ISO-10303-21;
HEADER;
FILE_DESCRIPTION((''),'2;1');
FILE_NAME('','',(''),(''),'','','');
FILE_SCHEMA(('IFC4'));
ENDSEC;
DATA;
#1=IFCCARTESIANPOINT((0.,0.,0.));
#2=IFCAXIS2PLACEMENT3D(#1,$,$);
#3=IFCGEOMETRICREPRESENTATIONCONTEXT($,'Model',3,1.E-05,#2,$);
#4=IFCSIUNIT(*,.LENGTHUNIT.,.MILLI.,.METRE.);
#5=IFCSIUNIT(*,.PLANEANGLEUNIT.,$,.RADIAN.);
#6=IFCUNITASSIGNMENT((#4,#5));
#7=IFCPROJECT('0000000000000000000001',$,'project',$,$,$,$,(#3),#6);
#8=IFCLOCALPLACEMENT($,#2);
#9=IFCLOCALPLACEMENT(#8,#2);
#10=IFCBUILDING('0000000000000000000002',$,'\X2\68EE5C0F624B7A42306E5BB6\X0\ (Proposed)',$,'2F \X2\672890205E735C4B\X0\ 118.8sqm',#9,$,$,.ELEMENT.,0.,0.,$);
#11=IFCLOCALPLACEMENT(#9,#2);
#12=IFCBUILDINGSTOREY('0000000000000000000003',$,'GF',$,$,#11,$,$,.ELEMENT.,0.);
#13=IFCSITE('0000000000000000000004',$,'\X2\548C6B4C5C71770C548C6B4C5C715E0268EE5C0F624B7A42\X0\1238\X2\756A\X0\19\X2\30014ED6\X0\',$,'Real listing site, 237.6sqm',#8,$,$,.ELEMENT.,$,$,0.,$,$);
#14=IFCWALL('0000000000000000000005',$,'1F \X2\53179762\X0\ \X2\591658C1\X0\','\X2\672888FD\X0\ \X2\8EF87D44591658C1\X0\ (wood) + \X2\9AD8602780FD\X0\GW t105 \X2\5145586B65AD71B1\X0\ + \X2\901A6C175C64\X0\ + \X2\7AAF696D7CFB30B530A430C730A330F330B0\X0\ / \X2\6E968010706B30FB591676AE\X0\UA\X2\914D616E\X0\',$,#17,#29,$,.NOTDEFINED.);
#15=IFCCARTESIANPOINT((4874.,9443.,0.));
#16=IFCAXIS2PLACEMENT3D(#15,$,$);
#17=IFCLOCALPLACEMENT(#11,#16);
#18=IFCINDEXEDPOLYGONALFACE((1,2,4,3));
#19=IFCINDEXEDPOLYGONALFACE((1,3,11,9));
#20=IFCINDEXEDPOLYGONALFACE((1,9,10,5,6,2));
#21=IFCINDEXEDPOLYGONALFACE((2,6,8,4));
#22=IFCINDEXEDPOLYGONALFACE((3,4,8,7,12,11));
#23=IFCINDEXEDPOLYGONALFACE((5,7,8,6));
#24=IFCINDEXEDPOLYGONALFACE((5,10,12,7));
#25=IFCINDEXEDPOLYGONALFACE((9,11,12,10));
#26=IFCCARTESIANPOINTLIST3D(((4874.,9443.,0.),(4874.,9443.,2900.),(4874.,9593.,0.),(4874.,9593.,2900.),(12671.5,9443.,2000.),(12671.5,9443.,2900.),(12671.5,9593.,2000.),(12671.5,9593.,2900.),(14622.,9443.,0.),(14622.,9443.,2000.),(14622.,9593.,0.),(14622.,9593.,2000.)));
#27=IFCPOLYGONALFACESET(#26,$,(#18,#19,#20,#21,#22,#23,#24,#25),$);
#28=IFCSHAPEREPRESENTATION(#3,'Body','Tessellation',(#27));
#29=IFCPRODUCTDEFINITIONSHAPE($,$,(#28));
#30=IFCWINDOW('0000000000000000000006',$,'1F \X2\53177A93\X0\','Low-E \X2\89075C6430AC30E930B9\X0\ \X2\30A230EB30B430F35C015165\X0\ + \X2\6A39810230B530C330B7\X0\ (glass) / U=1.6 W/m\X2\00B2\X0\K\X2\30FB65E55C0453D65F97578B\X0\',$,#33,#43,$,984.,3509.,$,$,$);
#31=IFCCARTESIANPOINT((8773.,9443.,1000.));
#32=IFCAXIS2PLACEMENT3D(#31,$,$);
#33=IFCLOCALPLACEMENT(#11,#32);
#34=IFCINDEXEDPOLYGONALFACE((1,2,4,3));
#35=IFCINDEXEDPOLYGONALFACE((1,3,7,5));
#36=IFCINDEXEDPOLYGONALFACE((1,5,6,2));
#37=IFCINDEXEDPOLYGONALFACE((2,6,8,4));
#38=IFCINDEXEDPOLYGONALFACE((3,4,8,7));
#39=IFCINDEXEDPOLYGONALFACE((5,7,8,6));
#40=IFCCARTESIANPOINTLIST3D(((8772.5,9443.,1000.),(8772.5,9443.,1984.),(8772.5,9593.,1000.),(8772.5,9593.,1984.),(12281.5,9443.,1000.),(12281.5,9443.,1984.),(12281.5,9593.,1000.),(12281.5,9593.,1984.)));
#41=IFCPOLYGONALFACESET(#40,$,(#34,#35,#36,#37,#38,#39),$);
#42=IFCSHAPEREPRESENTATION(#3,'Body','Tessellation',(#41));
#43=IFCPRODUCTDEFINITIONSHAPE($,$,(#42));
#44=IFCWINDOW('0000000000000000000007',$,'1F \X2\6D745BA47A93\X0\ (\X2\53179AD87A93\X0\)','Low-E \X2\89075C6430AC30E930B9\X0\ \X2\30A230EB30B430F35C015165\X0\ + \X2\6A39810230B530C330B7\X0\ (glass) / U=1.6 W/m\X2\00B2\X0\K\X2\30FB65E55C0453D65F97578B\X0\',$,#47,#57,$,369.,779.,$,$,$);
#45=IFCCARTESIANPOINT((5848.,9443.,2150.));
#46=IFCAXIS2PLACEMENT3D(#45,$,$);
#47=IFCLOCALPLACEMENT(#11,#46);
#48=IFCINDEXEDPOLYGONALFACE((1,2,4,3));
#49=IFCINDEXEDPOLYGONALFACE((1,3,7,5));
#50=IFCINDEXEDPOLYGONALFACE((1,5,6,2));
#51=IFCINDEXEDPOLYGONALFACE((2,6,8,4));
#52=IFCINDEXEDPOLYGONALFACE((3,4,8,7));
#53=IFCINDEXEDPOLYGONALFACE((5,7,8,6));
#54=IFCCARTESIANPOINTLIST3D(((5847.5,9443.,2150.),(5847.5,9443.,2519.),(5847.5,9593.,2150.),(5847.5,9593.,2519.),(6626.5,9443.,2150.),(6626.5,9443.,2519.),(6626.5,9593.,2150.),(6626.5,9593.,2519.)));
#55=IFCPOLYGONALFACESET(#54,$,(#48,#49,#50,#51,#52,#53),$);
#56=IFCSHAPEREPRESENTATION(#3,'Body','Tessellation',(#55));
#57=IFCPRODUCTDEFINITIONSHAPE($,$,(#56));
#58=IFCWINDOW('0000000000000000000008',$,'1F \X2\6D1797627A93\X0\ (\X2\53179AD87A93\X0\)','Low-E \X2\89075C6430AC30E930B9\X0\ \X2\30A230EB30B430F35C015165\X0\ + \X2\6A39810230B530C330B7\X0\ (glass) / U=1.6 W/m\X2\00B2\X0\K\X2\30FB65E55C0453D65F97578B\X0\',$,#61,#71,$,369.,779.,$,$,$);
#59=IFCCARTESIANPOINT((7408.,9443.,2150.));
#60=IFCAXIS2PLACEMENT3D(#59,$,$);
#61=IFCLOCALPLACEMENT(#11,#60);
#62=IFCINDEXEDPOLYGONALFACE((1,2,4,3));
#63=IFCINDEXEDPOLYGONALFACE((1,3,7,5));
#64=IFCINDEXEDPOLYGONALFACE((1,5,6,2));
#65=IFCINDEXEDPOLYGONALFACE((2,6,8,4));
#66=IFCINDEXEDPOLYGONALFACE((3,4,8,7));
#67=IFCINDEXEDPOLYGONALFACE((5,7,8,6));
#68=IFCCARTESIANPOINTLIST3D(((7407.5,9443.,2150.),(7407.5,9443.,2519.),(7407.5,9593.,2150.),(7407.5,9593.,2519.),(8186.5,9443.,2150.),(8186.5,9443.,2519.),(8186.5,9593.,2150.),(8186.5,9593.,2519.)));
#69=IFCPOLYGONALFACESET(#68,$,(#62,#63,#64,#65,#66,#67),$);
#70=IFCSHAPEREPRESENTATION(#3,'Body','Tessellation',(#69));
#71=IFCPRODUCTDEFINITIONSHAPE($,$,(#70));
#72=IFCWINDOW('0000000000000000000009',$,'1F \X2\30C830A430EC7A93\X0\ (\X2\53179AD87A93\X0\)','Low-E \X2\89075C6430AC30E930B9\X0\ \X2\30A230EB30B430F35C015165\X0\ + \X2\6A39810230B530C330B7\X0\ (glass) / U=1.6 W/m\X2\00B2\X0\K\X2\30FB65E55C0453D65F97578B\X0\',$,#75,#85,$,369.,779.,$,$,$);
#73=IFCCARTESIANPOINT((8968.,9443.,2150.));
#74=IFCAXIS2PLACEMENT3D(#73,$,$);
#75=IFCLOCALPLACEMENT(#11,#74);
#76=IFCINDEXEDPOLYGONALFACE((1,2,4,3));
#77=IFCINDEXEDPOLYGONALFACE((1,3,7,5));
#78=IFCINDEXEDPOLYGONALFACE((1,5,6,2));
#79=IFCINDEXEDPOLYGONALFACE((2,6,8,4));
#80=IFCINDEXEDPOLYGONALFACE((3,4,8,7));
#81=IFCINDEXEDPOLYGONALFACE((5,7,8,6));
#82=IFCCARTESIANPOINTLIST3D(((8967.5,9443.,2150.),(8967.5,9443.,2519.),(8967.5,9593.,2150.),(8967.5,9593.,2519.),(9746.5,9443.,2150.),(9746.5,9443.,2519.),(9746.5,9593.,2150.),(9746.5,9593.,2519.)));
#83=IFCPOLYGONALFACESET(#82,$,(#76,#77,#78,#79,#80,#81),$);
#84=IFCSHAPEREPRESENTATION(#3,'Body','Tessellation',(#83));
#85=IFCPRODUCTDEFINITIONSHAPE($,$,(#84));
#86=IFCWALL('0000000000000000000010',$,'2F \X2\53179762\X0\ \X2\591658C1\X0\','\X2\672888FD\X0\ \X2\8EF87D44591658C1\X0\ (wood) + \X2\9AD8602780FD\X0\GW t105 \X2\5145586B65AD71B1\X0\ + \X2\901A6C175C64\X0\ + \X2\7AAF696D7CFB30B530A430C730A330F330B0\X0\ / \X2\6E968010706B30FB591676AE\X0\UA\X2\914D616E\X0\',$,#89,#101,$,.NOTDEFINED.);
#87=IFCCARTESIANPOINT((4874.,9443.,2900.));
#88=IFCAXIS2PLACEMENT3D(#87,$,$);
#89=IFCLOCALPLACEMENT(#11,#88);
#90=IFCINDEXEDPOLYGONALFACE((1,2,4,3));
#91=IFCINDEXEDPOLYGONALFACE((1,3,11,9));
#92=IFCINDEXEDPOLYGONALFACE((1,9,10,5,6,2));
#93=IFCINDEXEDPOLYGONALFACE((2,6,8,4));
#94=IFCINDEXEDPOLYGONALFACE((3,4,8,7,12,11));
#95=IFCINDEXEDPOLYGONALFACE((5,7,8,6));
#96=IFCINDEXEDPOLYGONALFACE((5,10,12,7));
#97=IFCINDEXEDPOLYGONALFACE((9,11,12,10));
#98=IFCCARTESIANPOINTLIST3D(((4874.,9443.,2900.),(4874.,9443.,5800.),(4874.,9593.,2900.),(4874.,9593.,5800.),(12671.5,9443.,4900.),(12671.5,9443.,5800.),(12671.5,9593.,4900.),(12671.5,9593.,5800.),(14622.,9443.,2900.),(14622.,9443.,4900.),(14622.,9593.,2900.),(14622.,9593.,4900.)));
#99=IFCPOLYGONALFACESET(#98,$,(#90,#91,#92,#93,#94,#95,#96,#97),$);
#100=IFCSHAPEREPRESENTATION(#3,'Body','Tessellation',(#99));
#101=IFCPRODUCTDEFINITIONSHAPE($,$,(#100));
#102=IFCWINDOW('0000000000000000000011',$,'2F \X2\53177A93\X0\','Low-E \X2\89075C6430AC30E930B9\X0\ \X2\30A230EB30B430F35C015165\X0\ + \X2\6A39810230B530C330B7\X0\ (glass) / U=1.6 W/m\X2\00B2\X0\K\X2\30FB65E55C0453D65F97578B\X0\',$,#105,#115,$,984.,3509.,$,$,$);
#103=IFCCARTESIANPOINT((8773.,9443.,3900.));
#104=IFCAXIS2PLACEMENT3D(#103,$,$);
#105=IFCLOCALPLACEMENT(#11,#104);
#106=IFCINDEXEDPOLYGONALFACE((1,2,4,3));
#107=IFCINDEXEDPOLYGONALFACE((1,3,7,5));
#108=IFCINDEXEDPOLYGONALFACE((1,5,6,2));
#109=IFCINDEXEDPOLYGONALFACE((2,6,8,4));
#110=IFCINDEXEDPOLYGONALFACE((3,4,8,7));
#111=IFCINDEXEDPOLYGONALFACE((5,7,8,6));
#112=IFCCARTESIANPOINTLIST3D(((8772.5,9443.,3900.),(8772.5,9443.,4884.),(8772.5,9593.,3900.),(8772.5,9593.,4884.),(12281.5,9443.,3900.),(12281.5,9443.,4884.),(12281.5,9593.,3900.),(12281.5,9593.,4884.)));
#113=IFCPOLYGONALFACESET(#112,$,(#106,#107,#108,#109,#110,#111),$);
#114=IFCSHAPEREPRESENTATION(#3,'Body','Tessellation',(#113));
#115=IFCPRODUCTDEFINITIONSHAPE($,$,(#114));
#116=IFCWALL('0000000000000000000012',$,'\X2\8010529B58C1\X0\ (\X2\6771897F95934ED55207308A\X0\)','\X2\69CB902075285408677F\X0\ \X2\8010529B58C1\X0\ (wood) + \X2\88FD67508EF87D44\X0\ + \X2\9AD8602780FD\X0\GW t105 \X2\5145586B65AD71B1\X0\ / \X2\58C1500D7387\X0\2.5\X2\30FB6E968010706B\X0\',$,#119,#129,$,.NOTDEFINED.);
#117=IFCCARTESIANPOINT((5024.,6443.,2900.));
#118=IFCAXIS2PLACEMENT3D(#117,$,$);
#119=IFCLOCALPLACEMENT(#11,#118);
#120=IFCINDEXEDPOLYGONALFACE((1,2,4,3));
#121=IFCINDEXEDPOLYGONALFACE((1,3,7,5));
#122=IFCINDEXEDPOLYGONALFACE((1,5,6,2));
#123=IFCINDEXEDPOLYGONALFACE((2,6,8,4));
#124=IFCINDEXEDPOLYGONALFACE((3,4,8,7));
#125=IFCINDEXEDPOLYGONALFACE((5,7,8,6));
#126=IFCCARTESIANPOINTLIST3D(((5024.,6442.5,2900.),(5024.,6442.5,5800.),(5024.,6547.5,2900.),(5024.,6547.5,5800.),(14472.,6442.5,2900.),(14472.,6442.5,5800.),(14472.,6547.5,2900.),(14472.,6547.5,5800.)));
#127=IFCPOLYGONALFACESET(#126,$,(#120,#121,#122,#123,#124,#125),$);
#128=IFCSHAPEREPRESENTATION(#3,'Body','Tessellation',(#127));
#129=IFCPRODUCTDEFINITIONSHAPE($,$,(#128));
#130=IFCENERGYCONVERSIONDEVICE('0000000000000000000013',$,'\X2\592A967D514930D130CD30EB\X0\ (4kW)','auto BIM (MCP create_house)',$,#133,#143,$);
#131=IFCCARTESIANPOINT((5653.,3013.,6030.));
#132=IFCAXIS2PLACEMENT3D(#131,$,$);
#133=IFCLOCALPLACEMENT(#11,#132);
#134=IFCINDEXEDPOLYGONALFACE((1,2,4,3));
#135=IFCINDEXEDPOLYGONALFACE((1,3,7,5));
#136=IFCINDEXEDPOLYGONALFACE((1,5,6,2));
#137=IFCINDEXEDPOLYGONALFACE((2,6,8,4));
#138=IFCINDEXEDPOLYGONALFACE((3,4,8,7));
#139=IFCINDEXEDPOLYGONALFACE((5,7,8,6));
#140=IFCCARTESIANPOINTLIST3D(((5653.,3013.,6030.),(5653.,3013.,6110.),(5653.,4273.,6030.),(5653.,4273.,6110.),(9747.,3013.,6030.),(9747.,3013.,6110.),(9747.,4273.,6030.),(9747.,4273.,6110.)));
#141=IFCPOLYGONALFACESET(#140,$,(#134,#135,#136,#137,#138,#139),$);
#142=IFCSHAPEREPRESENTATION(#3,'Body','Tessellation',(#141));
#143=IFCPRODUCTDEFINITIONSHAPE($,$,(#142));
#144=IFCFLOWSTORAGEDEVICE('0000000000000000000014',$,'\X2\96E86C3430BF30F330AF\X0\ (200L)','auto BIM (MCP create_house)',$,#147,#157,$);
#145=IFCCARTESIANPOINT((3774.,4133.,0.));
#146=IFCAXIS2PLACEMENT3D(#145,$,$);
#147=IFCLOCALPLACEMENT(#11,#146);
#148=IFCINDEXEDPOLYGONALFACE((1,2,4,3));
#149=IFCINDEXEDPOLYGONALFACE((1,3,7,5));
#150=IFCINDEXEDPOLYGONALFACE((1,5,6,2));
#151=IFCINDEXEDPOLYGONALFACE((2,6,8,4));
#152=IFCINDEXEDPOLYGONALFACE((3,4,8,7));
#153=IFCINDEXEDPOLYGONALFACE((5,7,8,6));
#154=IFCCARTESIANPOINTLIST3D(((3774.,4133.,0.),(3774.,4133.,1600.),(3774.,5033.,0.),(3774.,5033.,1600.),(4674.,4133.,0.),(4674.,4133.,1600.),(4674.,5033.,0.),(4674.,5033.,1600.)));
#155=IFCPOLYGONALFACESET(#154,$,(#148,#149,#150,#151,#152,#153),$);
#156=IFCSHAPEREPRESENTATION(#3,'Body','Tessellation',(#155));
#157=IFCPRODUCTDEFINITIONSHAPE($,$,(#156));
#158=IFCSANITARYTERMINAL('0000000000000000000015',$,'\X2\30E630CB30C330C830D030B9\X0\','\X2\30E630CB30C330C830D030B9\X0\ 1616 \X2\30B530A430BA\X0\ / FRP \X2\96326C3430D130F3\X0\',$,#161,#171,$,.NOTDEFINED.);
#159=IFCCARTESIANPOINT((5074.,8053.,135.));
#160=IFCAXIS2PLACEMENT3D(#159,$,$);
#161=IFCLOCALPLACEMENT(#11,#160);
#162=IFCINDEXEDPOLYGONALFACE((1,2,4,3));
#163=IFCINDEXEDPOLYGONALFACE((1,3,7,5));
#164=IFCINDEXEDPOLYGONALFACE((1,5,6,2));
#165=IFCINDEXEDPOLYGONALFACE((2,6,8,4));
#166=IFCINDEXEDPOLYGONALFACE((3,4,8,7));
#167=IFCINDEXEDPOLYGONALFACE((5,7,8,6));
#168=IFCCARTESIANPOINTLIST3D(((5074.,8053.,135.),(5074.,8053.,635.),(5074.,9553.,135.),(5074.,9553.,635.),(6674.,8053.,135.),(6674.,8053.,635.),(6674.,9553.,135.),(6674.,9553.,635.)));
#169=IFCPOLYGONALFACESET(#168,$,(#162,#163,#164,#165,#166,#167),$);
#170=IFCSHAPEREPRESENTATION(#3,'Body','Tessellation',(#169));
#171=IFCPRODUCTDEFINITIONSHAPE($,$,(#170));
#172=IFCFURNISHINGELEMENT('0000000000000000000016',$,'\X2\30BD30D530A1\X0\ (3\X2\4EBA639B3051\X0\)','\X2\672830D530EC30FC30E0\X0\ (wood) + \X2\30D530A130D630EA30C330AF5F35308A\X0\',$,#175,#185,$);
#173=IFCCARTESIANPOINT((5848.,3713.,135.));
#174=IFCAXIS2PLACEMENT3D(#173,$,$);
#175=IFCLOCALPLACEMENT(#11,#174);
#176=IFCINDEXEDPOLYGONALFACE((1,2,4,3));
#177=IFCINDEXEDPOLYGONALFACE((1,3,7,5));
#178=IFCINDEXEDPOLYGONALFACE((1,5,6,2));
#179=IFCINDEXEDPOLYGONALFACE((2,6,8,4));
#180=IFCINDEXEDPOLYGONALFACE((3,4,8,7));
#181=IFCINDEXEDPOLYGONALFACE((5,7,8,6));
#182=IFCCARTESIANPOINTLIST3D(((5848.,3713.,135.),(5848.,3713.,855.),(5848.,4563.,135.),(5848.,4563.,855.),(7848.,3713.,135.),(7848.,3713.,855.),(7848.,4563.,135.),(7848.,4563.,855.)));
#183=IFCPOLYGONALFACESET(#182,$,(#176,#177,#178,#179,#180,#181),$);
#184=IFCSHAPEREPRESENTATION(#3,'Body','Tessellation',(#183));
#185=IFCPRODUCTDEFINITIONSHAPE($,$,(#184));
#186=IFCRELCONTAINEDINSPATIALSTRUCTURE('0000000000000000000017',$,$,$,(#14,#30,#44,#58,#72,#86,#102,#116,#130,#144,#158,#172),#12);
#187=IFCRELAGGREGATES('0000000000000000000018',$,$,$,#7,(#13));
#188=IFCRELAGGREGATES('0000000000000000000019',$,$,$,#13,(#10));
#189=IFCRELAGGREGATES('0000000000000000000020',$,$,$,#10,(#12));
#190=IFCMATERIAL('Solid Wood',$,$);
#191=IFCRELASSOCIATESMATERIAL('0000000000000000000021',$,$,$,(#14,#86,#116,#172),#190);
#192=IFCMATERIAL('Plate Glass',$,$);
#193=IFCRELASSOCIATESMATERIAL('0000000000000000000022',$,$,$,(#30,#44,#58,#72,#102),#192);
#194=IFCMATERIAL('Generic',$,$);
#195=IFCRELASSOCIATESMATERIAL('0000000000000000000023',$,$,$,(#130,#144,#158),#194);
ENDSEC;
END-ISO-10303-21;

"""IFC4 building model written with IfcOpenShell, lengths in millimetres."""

from ifc_helpers import new_model, si_unit, frame, frame_2d, origin, place, context, project, spatial, rectangle, extrude, material, element, fill, save


model = new_model("IFC4")

# Units and contexts
model_context = context("Model", 3, precision=1e-05, world=origin())
ifc_project = project(units=[si_unit("LENGTHUNIT", "METRE", prefix="MILLI"), si_unit("PLANEANGLEUNIT", "RADIAN")], contexts=[model_context])

# Site, building, storey
site_placement = place(None, origin())
site = spatial("IfcSite", under=ifc_project, at=site_placement, Name="和歌山県和歌山市森小手穂1238番19、他", ObjectType="Real listing site, 237.6sqm", CompositionType="ELEMENT", RefElevation=0.0)
building_placement = place(site_placement, origin())
building = spatial("IfcBuilding", under=site, at=building_placement, Name="森小手穂の家 (Proposed)", ObjectType="2F 木造平屋 118.8sqm", CompositionType="ELEMENT", ElevationOfRefHeight=0.0, ElevationOfTerrain=0.0)
storey_placement = place(building_placement, origin())
storey = spatial("IfcBuildingStorey", under=building, at=storey_placement, Name="GF", CompositionType="ELEMENT", Elevation=0.0)

# Wall, openings, windows
ifc_material_1 = material(Name="Solid Wood")
wall_1_placement = place(storey_placement, frame((4874.0, 9443.0, 0.0)))
wall_1 = element("IfcWall", 1, at=wall_1_placement, inside=storey, material=ifc_material_1, Name="1F 北面 外壁", Description="木製 軸組外壁 (wood) + 高性能GW t105 充填断熱 + 通気層 + 窯業系サイディング / 準耐火・外皮UA配慮", PredefinedType="NOTDEFINED", context=model_context, shape_type="SweptSolid", body=[
    extrude(rectangle(XDim=9748.0, YDim=150.0, at=frame_2d((4874.0, 75.0))), frame((4874.0, 9443.0, 0.0)), (0.0, 0.0, 1.0), 2900.0),
])
opening_1_placement = place(storey_placement, frame((8773.0, 9443.0, 1000.0)))
opening_1 = element("IfcOpeningElement", 2, at=opening_1_placement, cuts=wall_1, PredefinedType="NOTDEFINED", context=model_context, shape_type="SweptSolid", body=[
    extrude(rectangle(XDim=3509.0, YDim=150.0, at=frame_2d((1754.0, 75.0))), frame((8773.0, 9443.0, 1000.0)), (0.0, 0.0, 1.0), 984.0),
])
opening_2_placement = place(storey_placement, frame((5848.0, 9443.0, 2150.0)))
opening_2 = element("IfcOpeningElement", 3, at=opening_2_placement, cuts=wall_1, PredefinedType="NOTDEFINED", context=model_context, shape_type="SweptSolid", body=[
    extrude(rectangle(XDim=779.0, YDim=150.0, at=frame_2d((389.0, 75.0))), frame((5848.0, 9443.0, 2150.0)), (0.0, 0.0, 1.0), 369.0),
])
opening_3_placement = place(storey_placement, frame((7408.0, 9443.0, 2150.0)))
opening_3 = element("IfcOpeningElement", 4, at=opening_3_placement, cuts=wall_1, PredefinedType="NOTDEFINED", context=model_context, shape_type="SweptSolid", body=[
    extrude(rectangle(XDim=779.0, YDim=150.0, at=frame_2d((389.0, 75.0))), frame((7408.0, 9443.0, 2150.0)), (0.0, 0.0, 1.0), 369.0),
])
opening_4_placement = place(storey_placement, frame((8968.0, 9443.0, 2150.0)))
opening_4 = element("IfcOpeningElement", 5, at=opening_4_placement, cuts=wall_1, PredefinedType="NOTDEFINED", context=model_context, shape_type="SweptSolid", body=[
    extrude(rectangle(XDim=779.0, YDim=150.0, at=frame_2d((389.0, 75.0))), frame((8968.0, 9443.0, 2150.0)), (0.0, 0.0, 1.0), 369.0),
])
ifc_material_2 = material(Name="Plate Glass")
window_1_placement = place(storey_placement, frame((8773.0, 9443.0, 1000.0)))
window_1 = element("IfcWindow", 6, at=window_1_placement, inside=storey, material=ifc_material_2, Name="1F 北窓", Description="Low-E 複層ガラス アルゴン封入 + 樹脂サッシ (glass) / U=1.6 W/m²K・日射取得型", OverallHeight=984.0, OverallWidth=3509.0, context=model_context, shape_type="SweptSolid", body=[
    extrude(rectangle(XDim=3509.0, YDim=150.0, at=frame_2d((1754.0, 75.0))), frame((8773.0, 9443.0, 1000.0)), (0.0, 0.0, 1.0), 984.0),
])
fill(opening_1, window_1)
window_2_placement = place(storey_placement, frame((5848.0, 9443.0, 2150.0)))
window_2 = element("IfcWindow", 7, at=window_2_placement, inside=storey, material=ifc_material_2, Name="1F 浴室窓 (北高窓)", Description="Low-E 複層ガラス アルゴン封入 + 樹脂サッシ (glass) / U=1.6 W/m²K・日射取得型", OverallHeight=369.0, OverallWidth=779.0, context=model_context, shape_type="SweptSolid", body=[
    extrude(rectangle(XDim=779.0, YDim=150.0, at=frame_2d((389.0, 75.0))), frame((5848.0, 9443.0, 2150.0)), (0.0, 0.0, 1.0), 369.0),
])
fill(opening_2, window_2)
window_3_placement = place(storey_placement, frame((7408.0, 9443.0, 2150.0)))
window_3 = element("IfcWindow", 8, at=window_3_placement, inside=storey, material=ifc_material_2, Name="1F 洗面窓 (北高窓)", Description="Low-E 複層ガラス アルゴン封入 + 樹脂サッシ (glass) / U=1.6 W/m²K・日射取得型", OverallHeight=369.0, OverallWidth=779.0, context=model_context, shape_type="SweptSolid", body=[
    extrude(rectangle(XDim=779.0, YDim=150.0, at=frame_2d((389.0, 75.0))), frame((7408.0, 9443.0, 2150.0)), (0.0, 0.0, 1.0), 369.0),
])
fill(opening_3, window_3)
window_4_placement = place(storey_placement, frame((8968.0, 9443.0, 2150.0)))
window_4 = element("IfcWindow", 9, at=window_4_placement, inside=storey, material=ifc_material_2, Name="1F トイレ窓 (北高窓)", Description="Low-E 複層ガラス アルゴン封入 + 樹脂サッシ (glass) / U=1.6 W/m²K・日射取得型", OverallHeight=369.0, OverallWidth=779.0, context=model_context, shape_type="SweptSolid", body=[
    extrude(rectangle(XDim=779.0, YDim=150.0, at=frame_2d((389.0, 75.0))), frame((8968.0, 9443.0, 2150.0)), (0.0, 0.0, 1.0), 369.0),
])
fill(opening_4, window_4)

# Wall, opening, window
wall_2_placement = place(storey_placement, frame((4874.0, 9443.0, 2900.0)))
wall_2 = element("IfcWall", 10, at=wall_2_placement, inside=storey, material=ifc_material_1, Name="2F 北面 外壁", Description="木製 軸組外壁 (wood) + 高性能GW t105 充填断熱 + 通気層 + 窯業系サイディング / 準耐火・外皮UA配慮", PredefinedType="NOTDEFINED", context=model_context, shape_type="SweptSolid", body=[
    extrude(rectangle(XDim=9748.0, YDim=150.0, at=frame_2d((4874.0, 75.0))), frame((4874.0, 9443.0, 2900.0)), (0.0, 0.0, 1.0), 2900.0),
])
opening_5_placement = place(storey_placement, frame((8773.0, 9443.0, 3900.0)))
opening_5 = element("IfcOpeningElement", 11, at=opening_5_placement, cuts=wall_2, PredefinedType="NOTDEFINED", context=model_context, shape_type="SweptSolid", body=[
    extrude(rectangle(XDim=3509.0, YDim=150.0, at=frame_2d((1754.0, 75.0))), frame((8773.0, 9443.0, 3900.0)), (0.0, 0.0, 1.0), 984.0),
])
window_5_placement = place(storey_placement, frame((8773.0, 9443.0, 3900.0)))
window_5 = element("IfcWindow", 12, at=window_5_placement, inside=storey, material=ifc_material_2, Name="2F 北窓", Description="Low-E 複層ガラス アルゴン封入 + 樹脂サッシ (glass) / U=1.6 W/m²K・日射取得型", OverallHeight=984.0, OverallWidth=3509.0, context=model_context, shape_type="SweptSolid", body=[
    extrude(rectangle(XDim=3509.0, YDim=150.0, at=frame_2d((1754.0, 75.0))), frame((8773.0, 9443.0, 3900.0)), (0.0, 0.0, 1.0), 984.0),
])
fill(opening_5, window_5)

# Wall
wall_3_placement = place(storey_placement, frame((5024.0, 6443.0, 2900.0)))
element("IfcWall", 13, at=wall_3_placement, inside=storey, material=ifc_material_1, Name="耐力壁 (東西間仕切り)", Description="構造用合板 耐力壁 (wood) + 製材軸組 + 高性能GW t105 充填断熱 / 壁倍率2.5・準耐火", PredefinedType="NOTDEFINED", context=model_context, shape_type="SweptSolid", body=[
    extrude(rectangle(XDim=9448.0, YDim=105.0, at=frame_2d((4724.0, 52.0))), frame((5024.0, 6443.0, 2900.0)), (0.0, 0.0, 1.0), 2900.0),
])

# Energy conversion device
ifc_material_3 = material(Name="Generic")
energy_conversion_device_placement = place(storey_placement, frame((5653.0, 3013.0, 6030.0)))
element("IfcEnergyConversionDevice", 14, at=energy_conversion_device_placement, inside=storey, material=ifc_material_3, Name="太陽光パネル (4kW)", Description="auto BIM (MCP create_house)", context=model_context, shape_type="SweptSolid", body=[
    extrude(rectangle(XDim=4094.0, YDim=1260.0, at=frame_2d((2047.0, 630.0))), frame((5653.0, 3013.0, 6030.0)), (0.0, 0.0, 1.0), 80.0),
])

# Flow storage device
flow_storage_device_placement = place(storey_placement, frame((3774.0, 4133.0, 0.0)))
element("IfcFlowStorageDevice", 15, at=flow_storage_device_placement, inside=storey, material=ifc_material_3, Name="雨水タンク (200L)", Description="auto BIM (MCP create_house)", context=model_context, shape_type="SweptSolid", body=[
    extrude(rectangle(XDim=900.0, YDim=900.0, at=frame_2d((450.0, 450.0))), frame((3774.0, 4133.0, 0.0)), (0.0, 0.0, 1.0), 1600.0),
])

# Sanitary terminal
sanitary_terminal_placement = place(storey_placement, frame((5074.0, 8053.0, 135.0)))
element("IfcSanitaryTerminal", 16, at=sanitary_terminal_placement, inside=storey, material=ifc_material_3, Name="ユニットバス", Description="ユニットバス 1616 サイズ / FRP 防水パン", PredefinedType="NOTDEFINED", context=model_context, shape_type="SweptSolid", body=[
    extrude(rectangle(XDim=1600.0, YDim=1500.0, at=frame_2d((800.0, 750.0))), frame((5074.0, 8053.0, 135.0)), (0.0, 0.0, 1.0), 500.0),
])

# Furnishing element
furnishing_1_placement = place(storey_placement, frame((5848.0, 3713.0, 135.0)))
element("IfcFurnishingElement", 17, at=furnishing_1_placement, inside=storey, material=ifc_material_1, Name="ソファ (3人掛け)", Description="木フレーム (wood) + ファブリック張り", context=model_context, shape_type="SweptSolid", body=[
    extrude(rectangle(XDim=2000.0, YDim=850.0, at=frame_2d((1000.0, 425.0))), frame((5848.0, 3713.0, 135.0)), (0.0, 0.0, 1.0), 720.0),
])

save(model, "model.ifc")
